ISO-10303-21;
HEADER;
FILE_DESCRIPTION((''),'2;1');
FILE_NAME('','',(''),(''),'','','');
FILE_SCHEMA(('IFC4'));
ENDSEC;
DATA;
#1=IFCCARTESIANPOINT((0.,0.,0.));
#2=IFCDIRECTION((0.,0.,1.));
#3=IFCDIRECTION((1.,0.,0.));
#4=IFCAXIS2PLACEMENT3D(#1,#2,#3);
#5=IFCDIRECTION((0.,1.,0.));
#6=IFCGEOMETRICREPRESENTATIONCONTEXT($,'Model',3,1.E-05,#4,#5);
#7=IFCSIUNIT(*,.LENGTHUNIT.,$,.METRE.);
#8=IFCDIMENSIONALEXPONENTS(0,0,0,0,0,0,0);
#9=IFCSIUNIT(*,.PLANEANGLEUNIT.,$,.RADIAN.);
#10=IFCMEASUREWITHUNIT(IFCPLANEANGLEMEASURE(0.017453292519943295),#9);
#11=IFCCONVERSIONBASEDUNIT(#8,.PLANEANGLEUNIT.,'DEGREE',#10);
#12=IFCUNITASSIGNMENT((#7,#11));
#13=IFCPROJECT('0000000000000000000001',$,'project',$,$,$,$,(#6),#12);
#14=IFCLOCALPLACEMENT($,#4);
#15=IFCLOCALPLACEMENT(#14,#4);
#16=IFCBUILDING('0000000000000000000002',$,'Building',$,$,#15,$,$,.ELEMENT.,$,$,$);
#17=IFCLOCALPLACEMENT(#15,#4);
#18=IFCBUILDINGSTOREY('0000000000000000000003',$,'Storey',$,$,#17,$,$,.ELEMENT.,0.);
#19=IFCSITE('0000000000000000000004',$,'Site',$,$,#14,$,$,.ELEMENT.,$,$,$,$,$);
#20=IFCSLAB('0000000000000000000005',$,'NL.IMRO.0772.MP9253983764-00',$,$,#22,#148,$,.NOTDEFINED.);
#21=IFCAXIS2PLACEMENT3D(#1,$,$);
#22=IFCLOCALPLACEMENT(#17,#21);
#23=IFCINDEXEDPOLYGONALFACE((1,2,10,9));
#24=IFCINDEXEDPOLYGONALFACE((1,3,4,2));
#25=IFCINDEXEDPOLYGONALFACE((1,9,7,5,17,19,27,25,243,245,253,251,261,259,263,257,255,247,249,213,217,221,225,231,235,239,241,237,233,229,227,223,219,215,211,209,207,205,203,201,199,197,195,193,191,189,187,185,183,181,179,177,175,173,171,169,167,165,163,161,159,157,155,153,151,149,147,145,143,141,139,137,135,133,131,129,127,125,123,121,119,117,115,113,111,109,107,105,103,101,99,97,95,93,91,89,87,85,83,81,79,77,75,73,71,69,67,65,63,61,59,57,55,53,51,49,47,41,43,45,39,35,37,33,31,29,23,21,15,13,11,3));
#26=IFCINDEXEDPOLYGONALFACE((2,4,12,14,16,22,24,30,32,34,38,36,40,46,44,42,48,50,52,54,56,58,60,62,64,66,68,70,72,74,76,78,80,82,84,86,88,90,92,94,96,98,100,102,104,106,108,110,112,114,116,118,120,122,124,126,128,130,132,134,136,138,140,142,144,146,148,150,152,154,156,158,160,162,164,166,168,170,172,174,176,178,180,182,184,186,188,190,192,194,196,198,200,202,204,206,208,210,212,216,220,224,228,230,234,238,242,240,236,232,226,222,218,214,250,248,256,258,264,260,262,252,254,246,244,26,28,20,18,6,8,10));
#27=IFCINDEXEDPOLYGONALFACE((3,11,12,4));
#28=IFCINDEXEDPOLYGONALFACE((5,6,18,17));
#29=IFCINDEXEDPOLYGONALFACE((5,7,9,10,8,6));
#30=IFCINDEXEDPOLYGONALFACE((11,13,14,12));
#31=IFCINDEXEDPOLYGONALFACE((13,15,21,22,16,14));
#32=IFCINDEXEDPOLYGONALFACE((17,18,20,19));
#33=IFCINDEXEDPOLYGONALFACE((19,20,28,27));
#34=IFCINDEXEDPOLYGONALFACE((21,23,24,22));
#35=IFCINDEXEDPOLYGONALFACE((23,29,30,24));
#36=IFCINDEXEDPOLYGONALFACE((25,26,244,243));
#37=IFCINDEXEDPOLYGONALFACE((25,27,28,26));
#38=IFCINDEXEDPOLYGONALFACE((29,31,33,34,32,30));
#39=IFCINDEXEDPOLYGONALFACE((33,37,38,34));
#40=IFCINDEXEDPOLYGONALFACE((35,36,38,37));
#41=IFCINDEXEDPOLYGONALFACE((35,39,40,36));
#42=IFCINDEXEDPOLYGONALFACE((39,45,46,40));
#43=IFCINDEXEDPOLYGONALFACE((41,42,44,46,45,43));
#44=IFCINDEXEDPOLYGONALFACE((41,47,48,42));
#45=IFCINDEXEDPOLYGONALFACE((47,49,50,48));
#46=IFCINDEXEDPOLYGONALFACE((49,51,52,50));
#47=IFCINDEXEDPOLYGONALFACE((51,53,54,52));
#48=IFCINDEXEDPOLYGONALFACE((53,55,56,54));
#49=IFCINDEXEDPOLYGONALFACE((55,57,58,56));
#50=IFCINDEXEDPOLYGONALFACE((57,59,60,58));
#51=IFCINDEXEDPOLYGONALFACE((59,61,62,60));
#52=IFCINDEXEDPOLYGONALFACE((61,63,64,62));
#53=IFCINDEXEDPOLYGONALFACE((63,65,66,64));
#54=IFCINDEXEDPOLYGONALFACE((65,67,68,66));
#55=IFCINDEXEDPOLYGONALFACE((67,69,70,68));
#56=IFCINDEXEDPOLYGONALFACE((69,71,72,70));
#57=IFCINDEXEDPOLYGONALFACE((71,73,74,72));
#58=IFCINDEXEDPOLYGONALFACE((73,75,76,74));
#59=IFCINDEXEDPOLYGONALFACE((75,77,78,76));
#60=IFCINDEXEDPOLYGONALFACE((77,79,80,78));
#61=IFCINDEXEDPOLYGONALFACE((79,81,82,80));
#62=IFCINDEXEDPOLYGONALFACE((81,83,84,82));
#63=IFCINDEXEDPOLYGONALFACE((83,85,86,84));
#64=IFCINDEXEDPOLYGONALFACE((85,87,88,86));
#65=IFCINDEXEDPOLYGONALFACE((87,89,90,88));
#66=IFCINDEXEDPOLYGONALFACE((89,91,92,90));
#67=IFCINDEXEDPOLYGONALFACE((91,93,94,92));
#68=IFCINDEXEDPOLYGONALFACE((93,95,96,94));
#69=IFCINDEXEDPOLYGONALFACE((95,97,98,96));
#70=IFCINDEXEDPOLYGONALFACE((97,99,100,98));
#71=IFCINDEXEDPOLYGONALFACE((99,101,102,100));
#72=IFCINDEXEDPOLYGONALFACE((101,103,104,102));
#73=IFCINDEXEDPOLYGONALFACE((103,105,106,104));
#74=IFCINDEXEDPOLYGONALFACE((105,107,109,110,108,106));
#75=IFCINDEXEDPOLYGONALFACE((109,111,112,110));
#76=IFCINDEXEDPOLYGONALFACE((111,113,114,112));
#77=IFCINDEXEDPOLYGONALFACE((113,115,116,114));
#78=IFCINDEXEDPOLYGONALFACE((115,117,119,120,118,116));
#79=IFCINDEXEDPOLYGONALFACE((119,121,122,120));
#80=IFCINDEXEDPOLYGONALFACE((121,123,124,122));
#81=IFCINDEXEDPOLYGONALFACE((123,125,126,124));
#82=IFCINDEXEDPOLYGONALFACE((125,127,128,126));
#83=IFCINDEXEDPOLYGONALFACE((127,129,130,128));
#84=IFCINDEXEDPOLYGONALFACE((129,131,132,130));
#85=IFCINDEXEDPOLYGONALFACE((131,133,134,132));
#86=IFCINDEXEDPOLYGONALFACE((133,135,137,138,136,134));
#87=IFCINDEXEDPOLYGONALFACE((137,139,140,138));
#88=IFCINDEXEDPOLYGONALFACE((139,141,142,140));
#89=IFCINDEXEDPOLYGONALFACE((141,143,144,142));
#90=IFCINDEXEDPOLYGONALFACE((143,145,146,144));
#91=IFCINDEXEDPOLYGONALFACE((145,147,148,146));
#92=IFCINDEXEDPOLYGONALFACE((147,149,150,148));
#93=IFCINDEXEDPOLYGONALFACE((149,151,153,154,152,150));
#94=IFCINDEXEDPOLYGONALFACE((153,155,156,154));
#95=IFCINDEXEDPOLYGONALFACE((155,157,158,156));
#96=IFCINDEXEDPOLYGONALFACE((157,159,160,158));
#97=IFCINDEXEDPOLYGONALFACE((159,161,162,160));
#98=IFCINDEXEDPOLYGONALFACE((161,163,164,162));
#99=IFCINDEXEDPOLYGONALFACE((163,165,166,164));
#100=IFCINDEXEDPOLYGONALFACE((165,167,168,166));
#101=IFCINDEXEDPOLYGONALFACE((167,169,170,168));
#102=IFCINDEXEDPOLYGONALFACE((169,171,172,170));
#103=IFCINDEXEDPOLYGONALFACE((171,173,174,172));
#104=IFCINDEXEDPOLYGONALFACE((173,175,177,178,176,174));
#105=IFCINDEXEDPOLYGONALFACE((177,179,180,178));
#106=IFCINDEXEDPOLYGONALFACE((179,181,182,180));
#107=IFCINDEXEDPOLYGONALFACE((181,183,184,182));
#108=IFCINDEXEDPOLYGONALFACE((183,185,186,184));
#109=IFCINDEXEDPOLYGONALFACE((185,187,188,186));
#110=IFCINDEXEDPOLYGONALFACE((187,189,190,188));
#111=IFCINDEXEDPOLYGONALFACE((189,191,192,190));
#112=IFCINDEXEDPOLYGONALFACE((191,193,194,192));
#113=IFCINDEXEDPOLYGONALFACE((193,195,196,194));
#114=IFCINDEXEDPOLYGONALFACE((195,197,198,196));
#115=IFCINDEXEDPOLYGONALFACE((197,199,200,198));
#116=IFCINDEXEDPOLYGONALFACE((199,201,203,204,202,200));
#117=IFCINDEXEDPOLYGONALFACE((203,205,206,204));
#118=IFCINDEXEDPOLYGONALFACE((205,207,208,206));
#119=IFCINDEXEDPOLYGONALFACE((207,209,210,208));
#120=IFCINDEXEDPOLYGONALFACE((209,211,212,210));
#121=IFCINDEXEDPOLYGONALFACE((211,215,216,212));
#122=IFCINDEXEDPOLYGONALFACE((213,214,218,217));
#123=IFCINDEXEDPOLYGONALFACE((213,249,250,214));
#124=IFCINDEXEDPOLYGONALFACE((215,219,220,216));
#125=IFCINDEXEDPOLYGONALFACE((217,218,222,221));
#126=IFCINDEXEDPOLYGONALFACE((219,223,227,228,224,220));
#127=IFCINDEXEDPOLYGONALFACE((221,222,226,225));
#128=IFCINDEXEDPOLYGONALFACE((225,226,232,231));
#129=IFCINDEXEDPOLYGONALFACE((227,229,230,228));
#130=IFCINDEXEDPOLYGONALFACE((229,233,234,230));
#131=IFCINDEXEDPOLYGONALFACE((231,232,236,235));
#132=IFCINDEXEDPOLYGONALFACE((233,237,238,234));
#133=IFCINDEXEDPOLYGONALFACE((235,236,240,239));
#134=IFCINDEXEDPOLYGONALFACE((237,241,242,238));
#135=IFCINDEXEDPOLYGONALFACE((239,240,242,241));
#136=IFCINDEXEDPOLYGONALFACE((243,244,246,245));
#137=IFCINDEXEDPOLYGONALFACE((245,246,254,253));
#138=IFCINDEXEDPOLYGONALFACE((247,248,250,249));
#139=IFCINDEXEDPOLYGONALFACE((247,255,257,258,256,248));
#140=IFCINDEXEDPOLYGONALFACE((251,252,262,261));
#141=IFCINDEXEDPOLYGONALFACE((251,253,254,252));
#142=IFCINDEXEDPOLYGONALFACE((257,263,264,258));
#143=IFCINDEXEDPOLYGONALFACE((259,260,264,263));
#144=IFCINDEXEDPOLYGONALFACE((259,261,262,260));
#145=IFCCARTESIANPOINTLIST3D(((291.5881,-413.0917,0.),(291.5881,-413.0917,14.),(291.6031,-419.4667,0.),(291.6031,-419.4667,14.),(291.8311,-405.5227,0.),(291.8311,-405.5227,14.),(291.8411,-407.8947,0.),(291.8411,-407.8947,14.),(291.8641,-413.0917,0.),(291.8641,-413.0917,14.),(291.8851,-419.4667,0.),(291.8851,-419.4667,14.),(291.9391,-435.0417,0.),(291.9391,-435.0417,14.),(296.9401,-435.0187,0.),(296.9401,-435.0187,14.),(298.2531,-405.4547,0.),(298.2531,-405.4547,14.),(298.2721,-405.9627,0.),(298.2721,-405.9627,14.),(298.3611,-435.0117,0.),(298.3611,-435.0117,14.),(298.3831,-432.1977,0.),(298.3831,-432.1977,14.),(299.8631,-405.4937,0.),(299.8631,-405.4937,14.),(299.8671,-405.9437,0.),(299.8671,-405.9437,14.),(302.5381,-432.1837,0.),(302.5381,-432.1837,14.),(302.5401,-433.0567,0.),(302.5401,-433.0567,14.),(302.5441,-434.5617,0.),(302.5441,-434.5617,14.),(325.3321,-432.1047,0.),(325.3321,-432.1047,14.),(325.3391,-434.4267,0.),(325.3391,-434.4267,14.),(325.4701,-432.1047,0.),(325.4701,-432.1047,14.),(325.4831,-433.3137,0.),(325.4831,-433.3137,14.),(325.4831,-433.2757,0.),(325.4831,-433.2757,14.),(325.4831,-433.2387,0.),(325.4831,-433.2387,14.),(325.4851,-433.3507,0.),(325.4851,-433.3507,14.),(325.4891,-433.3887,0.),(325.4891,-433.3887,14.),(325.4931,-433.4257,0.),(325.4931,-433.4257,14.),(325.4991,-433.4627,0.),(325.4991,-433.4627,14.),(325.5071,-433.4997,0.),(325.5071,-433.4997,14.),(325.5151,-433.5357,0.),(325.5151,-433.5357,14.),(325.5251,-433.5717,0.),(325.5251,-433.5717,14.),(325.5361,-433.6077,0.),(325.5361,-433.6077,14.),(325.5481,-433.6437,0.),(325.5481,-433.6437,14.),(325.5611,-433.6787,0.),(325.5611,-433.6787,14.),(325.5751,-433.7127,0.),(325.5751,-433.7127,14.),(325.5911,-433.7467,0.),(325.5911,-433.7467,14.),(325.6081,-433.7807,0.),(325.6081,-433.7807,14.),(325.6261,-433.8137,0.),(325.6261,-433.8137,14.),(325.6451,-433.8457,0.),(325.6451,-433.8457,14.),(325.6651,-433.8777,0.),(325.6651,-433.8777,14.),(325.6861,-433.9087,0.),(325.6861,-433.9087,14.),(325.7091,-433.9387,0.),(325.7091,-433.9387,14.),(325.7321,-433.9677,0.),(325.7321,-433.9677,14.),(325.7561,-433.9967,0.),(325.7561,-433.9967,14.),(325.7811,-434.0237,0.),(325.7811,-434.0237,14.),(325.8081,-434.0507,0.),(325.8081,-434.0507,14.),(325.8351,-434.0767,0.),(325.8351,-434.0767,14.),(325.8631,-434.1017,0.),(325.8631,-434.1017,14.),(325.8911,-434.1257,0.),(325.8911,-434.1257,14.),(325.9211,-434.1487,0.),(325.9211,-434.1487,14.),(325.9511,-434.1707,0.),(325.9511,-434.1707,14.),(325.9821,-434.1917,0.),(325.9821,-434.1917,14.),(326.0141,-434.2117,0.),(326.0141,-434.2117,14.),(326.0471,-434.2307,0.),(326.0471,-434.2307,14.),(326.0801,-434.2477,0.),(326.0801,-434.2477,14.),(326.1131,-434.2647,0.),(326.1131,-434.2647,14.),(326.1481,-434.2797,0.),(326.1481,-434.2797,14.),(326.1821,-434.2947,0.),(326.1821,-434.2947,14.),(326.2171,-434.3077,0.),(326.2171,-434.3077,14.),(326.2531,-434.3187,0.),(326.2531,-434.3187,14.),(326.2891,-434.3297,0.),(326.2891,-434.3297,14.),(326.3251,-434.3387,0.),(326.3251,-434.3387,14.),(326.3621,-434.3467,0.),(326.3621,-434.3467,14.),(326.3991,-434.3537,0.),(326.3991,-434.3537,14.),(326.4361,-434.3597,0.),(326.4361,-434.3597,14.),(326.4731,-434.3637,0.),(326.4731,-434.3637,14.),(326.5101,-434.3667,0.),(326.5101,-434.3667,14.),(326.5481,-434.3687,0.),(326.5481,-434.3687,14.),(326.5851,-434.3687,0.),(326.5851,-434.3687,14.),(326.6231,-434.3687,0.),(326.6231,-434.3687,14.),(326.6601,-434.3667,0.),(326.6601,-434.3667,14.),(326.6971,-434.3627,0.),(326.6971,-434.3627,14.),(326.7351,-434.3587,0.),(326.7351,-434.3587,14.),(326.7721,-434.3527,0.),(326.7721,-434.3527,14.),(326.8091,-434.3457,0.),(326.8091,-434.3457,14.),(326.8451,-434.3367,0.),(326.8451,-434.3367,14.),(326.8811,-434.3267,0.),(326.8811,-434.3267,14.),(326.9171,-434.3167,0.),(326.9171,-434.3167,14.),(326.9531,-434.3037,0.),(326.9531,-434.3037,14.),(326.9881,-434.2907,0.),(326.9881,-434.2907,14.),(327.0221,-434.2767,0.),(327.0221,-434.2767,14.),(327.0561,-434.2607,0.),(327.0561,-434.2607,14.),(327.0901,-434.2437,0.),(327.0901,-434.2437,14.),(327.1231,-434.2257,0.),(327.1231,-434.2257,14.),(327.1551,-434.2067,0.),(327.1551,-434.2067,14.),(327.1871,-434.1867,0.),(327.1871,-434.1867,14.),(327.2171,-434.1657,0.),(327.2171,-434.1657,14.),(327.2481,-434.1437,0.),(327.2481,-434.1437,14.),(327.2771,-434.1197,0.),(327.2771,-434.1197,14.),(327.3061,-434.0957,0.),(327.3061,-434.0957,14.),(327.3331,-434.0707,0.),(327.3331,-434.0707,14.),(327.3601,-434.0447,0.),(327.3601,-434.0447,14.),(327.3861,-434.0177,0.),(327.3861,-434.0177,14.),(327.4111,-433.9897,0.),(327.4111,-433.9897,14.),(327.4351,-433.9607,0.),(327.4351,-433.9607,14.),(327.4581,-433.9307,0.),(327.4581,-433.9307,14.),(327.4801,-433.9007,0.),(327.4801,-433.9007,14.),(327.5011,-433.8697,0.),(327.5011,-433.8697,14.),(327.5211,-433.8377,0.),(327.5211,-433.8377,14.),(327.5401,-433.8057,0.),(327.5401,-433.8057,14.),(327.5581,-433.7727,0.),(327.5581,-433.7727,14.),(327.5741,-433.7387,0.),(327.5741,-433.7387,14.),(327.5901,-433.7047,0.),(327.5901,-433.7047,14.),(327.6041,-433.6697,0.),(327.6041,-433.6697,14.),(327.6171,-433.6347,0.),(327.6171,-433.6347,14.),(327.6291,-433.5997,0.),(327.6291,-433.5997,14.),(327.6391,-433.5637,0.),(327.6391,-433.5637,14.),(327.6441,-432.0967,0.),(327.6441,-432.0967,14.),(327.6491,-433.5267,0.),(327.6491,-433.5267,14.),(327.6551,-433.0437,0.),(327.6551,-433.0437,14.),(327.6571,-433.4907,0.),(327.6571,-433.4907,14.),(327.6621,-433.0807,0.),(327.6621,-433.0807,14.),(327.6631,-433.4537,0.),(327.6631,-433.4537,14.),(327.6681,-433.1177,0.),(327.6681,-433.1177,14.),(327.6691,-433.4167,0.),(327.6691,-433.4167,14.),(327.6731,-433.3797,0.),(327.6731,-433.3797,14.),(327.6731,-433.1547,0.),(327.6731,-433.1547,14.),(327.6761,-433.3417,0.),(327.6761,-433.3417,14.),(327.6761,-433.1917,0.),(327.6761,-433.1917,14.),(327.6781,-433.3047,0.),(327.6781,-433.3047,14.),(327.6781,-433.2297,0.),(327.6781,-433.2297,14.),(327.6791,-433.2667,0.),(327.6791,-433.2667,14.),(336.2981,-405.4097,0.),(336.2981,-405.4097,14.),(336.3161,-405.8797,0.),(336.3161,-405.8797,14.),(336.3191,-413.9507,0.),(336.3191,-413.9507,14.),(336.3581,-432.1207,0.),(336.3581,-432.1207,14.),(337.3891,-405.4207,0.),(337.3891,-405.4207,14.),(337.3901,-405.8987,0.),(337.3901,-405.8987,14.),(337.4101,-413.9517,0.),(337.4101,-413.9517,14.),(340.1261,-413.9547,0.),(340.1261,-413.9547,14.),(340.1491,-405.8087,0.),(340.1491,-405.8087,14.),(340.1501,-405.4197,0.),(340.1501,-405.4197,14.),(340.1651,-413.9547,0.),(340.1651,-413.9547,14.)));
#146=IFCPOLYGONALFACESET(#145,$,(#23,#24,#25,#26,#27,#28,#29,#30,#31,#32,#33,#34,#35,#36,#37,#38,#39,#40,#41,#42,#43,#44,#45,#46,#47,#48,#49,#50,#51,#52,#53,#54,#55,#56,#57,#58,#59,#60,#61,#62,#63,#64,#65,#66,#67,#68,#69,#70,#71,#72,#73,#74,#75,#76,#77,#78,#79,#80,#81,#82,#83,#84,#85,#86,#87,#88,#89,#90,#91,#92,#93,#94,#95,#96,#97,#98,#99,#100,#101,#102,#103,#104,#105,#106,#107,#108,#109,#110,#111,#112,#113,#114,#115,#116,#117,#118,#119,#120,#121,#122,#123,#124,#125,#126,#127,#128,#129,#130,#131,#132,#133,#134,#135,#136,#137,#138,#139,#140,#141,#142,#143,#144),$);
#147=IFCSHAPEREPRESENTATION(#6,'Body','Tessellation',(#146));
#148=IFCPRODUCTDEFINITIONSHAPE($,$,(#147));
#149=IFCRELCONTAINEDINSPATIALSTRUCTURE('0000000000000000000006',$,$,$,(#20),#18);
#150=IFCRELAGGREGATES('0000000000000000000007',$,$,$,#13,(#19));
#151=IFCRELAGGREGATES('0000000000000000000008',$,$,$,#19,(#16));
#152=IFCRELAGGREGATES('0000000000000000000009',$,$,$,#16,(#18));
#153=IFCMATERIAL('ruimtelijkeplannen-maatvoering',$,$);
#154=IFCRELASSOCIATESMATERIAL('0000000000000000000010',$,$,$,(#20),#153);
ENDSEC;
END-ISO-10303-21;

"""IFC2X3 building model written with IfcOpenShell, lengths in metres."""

from ifc_helpers import new_model, entity, si_unit, converted_unit, direction, origin_with_axes, place, context, project, spatial, polyline, outline, extrude, material, element, save


model = new_model("IFC2X3")

# Units and contexts
model_context = context("Model", 3, precision=1e-05, world=origin_with_axes(), true_north=direction((0.0, 1.0, 0.0)))
ifc_project = project(units=[si_unit("LENGTHUNIT", "METRE"), converted_unit("PLANEANGLEUNIT", "DEGREE", entity("IfcPlaneAngleMeasure", 0.017453292519943295), si_unit("PLANEANGLEUNIT", "RADIAN"), dimensions=[0, 0, 0, 0, 0, 0, 0])], contexts=[model_context])

# Site, building, storey
site_placement = place(None, origin_with_axes())
site = spatial("IfcSite", under=ifc_project, at=site_placement, Name="Site", CompositionType="ELEMENT")
building_placement = place(site_placement, origin_with_axes())
building = spatial("IfcBuilding", under=site, at=building_placement, Name="Building", CompositionType="ELEMENT")
storey_placement = place(building_placement, origin_with_axes())
storey = spatial("IfcBuildingStorey", under=building, at=storey_placement, Name="Storey", CompositionType="ELEMENT", Elevation=0.0)

# Slab
ifc_material = material(Name="ruimtelijkeplannen-maatvoering")
slab_1_placement = place(storey_placement, origin_with_axes())
element("IfcSlab", 1, at=slab_1_placement, inside=storey, material=ifc_material, Name="NL.IMRO.0772.MP9253983764-00", PredefinedType="NOTDEFINED", context=model_context, shape_type="SweptSolid", body=[
    extrude(outline(polyline([(327.6621, -433.0807), (327.6681, -433.1177), (327.6731, -433.1547), (327.6761, -433.1917), (327.6781, -433.2297), (327.6791, -433.2667), (327.6781, -433.3047), (327.6761, -433.3417), (327.6731, -433.3797), (327.6691, -433.4167), (327.6631, -433.4537), (327.6571, -433.4907), (327.6491, -433.5267), (327.6391, -433.5637), (327.6291, -433.5997), (327.6171, -433.6347), (327.6041, -433.6697), (327.5901, -433.7047), (327.5741, -433.7387), (327.5581, -433.7727), (327.5401, -433.8057), (327.5211, -433.8377), (327.5011, -433.8697), (327.4801, -433.9007), (327.4581, -433.9307), (327.4351, -433.9607), (327.4111, -433.9897), (327.3861, -434.0177), (327.3601, -434.0447), (327.3331, -434.0707), (327.3061, -434.0957), (327.2771, -434.1197), (327.2481, -434.1437), (327.2171, -434.1657), (327.1871, -434.1867), (327.1551, -434.2067), (327.1231, -434.2257), (327.0901, -434.2437), (327.0561, -434.2607), (327.0221, -434.2767), (326.9881, -434.2907), (326.9531, -434.3037), (326.9171, -434.3167), (326.8811, -434.3267), (326.8451, -434.3367), (326.8091, -434.3457), (326.7721, -434.3527), (326.7351, -434.3587), (326.6971, -434.3627), (326.6601, -434.3667), (326.6231, -434.3687), (326.5851, -434.3687), (326.5481, -434.3687), (326.5101, -434.3667), (326.4731, -434.3637), (326.4361, -434.3597), (326.3991, -434.3537), (326.3621, -434.3467), (326.3251, -434.3387), (326.2891, -434.3297), (326.2531, -434.3187), (326.2171, -434.3077), (326.1821, -434.2947), (326.1481, -434.2797), (326.1131, -434.2647), (326.0801, -434.2477), (326.0471, -434.2307), (326.0141, -434.2117), (325.9821, -434.1917), (325.9511, -434.1707), (325.9211, -434.1487), (325.8911, -434.1257), (325.8631, -434.1017), (325.8351, -434.0767), (325.8081, -434.0507), (325.7811, -434.0237), (325.7561, -433.9967), (325.7321, -433.9677), (325.7091, -433.9387), (325.6861, -433.9087), (325.6651, -433.8777), (325.6451, -433.8457), (325.6261, -433.8137), (325.6081, -433.7807), (325.5911, -433.7467), (325.5751, -433.7127), (325.5611, -433.6787), (325.5481, -433.6437), (325.5361, -433.6077), (325.5251, -433.5717), (325.5151, -433.5357), (325.5071, -433.4997), (325.4991, -433.4627), (325.4931, -433.4257), (325.4891, -433.3887), (325.4851, -433.3507), (325.4831, -433.3137), (325.4831, -433.2757), (325.4831, -433.2387), (325.4701, -432.1047), (325.3321, -432.1047), (325.3391, -434.4267), (302.5441, -434.5617), (302.5401, -433.0567), (302.5381, -432.1837), (298.3831, -432.1977), (298.3611, -435.0117), (296.9401, -435.0187), (291.9391, -435.0417), (291.8851, -419.4667), (291.6031, -419.4667), (291.5881, -413.0917), (291.8641, -413.0917), (291.8411, -407.8947), (291.8311, -405.5227), (298.2531, -405.4547), (298.2721, -405.9627), (299.8671, -405.9437), (299.8631, -405.4937), (336.2981, -405.4097), (336.3161, -405.8797), (337.3901, -405.8987), (337.3891, -405.4207), (340.1501, -405.4197), (340.1491, -405.8087), (340.1651, -413.9547), (340.1261, -413.9547), (337.4101, -413.9517), (336.3191, -413.9507), (336.3581, -432.1207), (327.6441, -432.0967), (327.6551, -433.0437), (327.6621, -433.0807)])), origin_with_axes(), (0.0, 0.0, 1.0), 14.0),
])

save(model, "model.ifc")
